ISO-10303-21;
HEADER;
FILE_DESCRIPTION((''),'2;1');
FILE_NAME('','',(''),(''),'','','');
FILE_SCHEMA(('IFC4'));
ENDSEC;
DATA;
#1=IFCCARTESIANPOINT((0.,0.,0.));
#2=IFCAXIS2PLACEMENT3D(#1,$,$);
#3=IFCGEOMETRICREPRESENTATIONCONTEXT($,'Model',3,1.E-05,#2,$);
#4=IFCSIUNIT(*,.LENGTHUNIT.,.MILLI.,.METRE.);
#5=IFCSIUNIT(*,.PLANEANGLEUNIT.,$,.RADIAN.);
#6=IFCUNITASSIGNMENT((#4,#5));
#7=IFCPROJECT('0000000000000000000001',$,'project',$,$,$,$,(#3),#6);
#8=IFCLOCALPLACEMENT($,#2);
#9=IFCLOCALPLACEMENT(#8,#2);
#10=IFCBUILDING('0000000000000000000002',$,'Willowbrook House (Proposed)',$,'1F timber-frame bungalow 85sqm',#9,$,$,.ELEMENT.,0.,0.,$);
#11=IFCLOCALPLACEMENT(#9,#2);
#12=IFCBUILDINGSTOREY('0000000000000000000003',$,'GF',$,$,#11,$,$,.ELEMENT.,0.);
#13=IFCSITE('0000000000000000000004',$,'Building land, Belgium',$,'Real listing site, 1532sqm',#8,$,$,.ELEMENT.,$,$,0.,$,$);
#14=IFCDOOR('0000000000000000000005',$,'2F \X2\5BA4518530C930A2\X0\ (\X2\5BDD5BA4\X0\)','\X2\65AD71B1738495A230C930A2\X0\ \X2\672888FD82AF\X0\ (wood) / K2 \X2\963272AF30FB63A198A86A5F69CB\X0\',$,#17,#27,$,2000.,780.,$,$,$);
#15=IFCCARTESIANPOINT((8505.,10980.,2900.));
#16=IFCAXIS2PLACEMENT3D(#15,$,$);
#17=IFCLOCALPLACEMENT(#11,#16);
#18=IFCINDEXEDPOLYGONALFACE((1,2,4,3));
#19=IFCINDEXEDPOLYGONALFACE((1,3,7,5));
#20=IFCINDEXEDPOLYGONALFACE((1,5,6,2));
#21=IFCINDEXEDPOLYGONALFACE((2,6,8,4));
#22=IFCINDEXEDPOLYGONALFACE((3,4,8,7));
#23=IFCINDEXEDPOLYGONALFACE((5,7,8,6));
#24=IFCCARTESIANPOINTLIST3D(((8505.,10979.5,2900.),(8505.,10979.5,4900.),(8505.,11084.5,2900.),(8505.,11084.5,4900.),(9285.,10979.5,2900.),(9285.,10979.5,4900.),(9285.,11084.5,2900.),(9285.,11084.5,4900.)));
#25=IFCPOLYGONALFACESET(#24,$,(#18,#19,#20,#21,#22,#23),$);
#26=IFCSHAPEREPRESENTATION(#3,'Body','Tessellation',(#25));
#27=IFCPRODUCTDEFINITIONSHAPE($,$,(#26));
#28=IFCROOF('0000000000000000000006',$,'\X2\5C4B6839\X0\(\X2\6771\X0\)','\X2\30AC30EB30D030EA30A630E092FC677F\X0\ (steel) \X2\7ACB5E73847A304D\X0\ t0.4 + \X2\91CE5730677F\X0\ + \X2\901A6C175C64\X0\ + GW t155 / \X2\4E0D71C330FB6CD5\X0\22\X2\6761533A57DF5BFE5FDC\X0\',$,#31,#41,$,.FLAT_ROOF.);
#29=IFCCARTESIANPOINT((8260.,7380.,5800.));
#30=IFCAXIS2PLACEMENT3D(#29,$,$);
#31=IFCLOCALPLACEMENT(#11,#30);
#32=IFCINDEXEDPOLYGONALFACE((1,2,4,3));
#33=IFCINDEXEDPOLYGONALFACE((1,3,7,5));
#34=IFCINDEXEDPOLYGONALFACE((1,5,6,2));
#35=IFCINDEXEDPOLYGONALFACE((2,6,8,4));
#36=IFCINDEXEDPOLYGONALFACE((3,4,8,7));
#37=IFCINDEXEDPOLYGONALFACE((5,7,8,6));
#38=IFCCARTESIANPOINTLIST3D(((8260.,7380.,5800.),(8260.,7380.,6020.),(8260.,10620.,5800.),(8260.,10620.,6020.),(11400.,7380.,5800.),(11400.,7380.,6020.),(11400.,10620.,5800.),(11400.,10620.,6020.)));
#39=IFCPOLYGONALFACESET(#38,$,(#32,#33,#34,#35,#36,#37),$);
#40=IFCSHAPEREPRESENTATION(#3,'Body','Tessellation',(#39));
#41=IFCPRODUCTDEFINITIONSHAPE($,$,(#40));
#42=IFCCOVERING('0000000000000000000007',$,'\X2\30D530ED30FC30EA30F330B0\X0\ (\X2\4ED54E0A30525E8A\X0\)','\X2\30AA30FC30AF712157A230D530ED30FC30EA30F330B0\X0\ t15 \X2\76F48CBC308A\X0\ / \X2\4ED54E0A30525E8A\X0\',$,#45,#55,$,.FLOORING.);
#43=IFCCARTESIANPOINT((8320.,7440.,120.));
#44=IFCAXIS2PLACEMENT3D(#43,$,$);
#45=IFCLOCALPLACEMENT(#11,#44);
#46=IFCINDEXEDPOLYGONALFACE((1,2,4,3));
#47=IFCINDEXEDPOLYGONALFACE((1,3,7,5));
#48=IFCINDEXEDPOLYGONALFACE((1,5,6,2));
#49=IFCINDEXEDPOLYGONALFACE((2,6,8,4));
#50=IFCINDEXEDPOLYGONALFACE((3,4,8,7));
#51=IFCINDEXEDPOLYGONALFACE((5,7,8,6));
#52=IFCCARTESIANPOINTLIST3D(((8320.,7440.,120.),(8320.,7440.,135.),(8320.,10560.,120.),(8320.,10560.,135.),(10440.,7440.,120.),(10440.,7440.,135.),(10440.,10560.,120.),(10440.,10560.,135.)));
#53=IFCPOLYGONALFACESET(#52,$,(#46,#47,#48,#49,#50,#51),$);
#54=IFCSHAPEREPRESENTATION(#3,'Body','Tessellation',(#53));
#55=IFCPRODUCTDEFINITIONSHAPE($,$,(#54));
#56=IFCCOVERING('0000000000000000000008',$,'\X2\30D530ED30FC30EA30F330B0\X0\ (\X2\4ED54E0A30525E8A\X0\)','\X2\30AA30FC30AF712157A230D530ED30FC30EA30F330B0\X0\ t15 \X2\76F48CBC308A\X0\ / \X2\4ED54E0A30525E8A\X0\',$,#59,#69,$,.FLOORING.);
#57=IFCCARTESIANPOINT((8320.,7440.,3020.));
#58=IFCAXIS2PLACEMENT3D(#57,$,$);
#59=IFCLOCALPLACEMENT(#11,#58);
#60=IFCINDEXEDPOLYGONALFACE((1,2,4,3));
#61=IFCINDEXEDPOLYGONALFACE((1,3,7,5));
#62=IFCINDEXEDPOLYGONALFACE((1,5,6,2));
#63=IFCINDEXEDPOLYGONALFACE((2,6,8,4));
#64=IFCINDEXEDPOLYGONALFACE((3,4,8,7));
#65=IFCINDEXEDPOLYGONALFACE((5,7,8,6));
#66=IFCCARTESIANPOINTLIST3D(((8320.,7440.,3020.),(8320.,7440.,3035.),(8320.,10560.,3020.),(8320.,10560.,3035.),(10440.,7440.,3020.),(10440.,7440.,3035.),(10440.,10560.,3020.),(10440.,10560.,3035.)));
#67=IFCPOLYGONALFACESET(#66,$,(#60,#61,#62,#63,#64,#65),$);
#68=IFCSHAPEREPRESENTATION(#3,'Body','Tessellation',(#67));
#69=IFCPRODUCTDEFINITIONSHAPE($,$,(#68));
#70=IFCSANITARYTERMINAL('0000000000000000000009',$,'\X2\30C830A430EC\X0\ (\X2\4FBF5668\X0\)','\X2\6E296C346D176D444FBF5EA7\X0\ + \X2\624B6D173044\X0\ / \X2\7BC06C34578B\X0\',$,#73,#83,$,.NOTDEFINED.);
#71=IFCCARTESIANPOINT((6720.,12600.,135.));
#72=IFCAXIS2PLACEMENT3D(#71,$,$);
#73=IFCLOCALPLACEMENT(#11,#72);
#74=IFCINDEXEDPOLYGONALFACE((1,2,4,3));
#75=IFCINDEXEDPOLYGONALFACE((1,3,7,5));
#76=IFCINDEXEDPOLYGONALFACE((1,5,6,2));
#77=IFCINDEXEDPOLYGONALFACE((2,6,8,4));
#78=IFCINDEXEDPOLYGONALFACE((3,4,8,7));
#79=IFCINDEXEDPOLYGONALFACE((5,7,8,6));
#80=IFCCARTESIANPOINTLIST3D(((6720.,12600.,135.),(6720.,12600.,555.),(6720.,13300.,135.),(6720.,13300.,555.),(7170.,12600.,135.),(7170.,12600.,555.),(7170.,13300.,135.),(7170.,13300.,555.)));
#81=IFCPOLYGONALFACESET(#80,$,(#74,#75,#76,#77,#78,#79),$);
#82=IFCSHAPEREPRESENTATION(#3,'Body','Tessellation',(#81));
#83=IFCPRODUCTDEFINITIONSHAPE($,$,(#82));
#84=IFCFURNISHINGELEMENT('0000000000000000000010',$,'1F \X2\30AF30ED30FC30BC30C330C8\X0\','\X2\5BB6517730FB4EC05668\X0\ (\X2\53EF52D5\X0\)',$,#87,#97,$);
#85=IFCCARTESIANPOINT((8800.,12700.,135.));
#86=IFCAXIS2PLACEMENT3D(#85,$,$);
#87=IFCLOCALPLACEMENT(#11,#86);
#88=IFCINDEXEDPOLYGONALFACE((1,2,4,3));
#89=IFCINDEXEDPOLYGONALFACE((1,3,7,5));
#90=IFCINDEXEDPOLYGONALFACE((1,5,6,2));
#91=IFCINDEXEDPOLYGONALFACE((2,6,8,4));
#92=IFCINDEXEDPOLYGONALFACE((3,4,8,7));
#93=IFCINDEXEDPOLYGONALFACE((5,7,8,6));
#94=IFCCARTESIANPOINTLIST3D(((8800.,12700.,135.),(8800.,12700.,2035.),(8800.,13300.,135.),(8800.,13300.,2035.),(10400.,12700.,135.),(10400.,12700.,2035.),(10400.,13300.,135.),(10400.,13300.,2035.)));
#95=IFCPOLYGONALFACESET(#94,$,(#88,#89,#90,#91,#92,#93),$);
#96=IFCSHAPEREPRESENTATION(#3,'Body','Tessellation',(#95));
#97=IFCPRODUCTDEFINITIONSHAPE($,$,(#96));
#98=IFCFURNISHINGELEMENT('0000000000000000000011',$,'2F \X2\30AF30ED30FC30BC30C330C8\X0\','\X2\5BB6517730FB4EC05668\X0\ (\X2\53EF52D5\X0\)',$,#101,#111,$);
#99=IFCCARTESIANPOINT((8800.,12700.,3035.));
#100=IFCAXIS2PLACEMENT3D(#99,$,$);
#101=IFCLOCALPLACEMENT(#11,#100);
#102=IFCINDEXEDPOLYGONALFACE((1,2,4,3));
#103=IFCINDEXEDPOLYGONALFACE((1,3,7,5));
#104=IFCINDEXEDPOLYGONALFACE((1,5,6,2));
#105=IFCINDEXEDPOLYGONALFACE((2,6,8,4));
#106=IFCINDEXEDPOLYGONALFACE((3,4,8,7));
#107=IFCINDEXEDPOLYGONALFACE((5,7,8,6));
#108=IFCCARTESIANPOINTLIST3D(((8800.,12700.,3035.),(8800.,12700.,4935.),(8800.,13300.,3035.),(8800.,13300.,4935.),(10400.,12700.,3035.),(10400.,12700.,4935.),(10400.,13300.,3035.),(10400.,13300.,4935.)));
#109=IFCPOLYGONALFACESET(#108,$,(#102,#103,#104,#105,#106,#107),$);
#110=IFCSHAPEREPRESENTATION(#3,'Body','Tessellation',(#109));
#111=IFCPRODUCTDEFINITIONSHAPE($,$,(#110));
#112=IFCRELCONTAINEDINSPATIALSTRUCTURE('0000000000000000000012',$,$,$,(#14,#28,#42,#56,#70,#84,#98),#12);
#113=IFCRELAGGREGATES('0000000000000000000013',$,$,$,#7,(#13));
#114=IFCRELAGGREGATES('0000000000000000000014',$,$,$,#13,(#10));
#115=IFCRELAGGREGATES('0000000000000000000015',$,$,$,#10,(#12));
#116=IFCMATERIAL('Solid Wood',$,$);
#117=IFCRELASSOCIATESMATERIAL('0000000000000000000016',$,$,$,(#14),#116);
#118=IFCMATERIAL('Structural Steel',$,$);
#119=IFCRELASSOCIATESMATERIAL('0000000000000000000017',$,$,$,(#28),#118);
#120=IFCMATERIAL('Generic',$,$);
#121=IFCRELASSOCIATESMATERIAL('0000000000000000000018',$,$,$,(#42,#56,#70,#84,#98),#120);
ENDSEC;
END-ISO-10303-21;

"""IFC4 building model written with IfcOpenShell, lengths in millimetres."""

from ifc_helpers import new_model, si_unit, frame, frame_2d, origin, place, context, project, spatial, rectangle, extrude, material, element, save


model = new_model("IFC4")

# Units and contexts
model_context = context("Model", 3, precision=1e-05, world=origin())
ifc_project = project(units=[si_unit("LENGTHUNIT", "METRE", prefix="MILLI"), si_unit("PLANEANGLEUNIT", "RADIAN")], contexts=[model_context])

# Site, building, storey
site_placement = place(None, origin())
site = spatial("IfcSite", under=ifc_project, at=site_placement, Name="Building land, Belgium", ObjectType="Real listing site, 1532sqm", CompositionType="ELEMENT", RefElevation=0.0)
building_placement = place(site_placement, origin())
building = spatial("IfcBuilding", under=site, at=building_placement, Name="Willowbrook House (Proposed)", ObjectType="1F timber-frame bungalow 85sqm", CompositionType="ELEMENT", ElevationOfRefHeight=0.0, ElevationOfTerrain=0.0)
storey_placement = place(building_placement, origin())
storey = spatial("IfcBuildingStorey", under=building, at=storey_placement, Name="GF", CompositionType="ELEMENT", Elevation=0.0)

# Shared definitions
ifc_material_1 = material(Name="Solid Wood")

# Door
door_1_placement = place(storey_placement, frame((8505.0, 10980.0, 2900.0)))
element("IfcDoor", 1, at=door_1_placement, inside=storey, material=ifc_material_1, Name="2F 室内ドア (寝室)", Description="断熱玄関ドア 木製芯 (wood) / K2 防犯・採風機構", OverallHeight=2000.0, OverallWidth=780.0, context=model_context, shape_type="SweptSolid", body=[
    extrude(rectangle(XDim=780.0, YDim=105.0, at=frame_2d((390.0, 52.0))), frame((8505.0, 10980.0, 2900.0)), (0.0, 0.0, 1.0), 2000.0),
])

# Roof
ifc_material_2 = material(Name="Structural Steel")
roof_placement = place(storey_placement, frame((8260.0, 7380.0, 5800.0)))
element("IfcRoof", 2, at=roof_placement, inside=storey, material=ifc_material_2, Name="屋根(東)", Description="ガルバリウム鋼板 (steel) 立平葺き t0.4 + 野地板 + 通気層 + GW t155 / 不燃・法22条区域対応", PredefinedType="FLAT_ROOF", context=model_context, shape_type="SweptSolid", body=[
    extrude(rectangle(XDim=3140.0, YDim=3240.0, at=frame_2d((1570.0, 1620.0))), frame((8260.0, 7380.0, 5800.0)), (0.0, 0.0, 1.0), 220.0),
])

# Coverings
ifc_material_3 = material(Name="Generic")
covering_1_placement = place(storey_placement, frame((8320.0, 7440.0, 120.0)))
element("IfcCovering", 3, at=covering_1_placement, inside=storey, material=ifc_material_3, Name="フローリング (仕上げ床)", Description="オーク無垢フローリング t15 直貼り / 仕上げ床", PredefinedType="FLOORING", context=model_context, shape_type="SweptSolid", body=[
    extrude(rectangle(XDim=2120.0, YDim=3120.0, at=frame_2d((1060.0, 1560.0))), frame((8320.0, 7440.0, 120.0)), (0.0, 0.0, 1.0), 15.0),
])
covering_2_placement = place(storey_placement, frame((8320.0, 7440.0, 3020.0)))
element("IfcCovering", 4, at=covering_2_placement, inside=storey, material=ifc_material_3, Name="フローリング (仕上げ床)", Description="オーク無垢フローリング t15 直貼り / 仕上げ床", PredefinedType="FLOORING", context=model_context, shape_type="SweptSolid", body=[
    extrude(rectangle(XDim=2120.0, YDim=3120.0, at=frame_2d((1060.0, 1560.0))), frame((8320.0, 7440.0, 3020.0)), (0.0, 0.0, 1.0), 15.0),
])

# Sanitary terminal
sanitary_terminal_placement = place(storey_placement, frame((6720.0, 12600.0, 135.0)))
element("IfcSanitaryTerminal", 5, at=sanitary_terminal_placement, inside=storey, material=ifc_material_3, Name="トイレ (便器)", Description="温水洗浄便座 + 手洗い / 節水型", PredefinedType="NOTDEFINED", context=model_context, shape_type="SweptSolid", body=[
    extrude(rectangle(XDim=450.0, YDim=700.0, at=frame_2d((225.0, 350.0))), frame((6720.0, 12600.0, 135.0)), (0.0, 0.0, 1.0), 420.0),
])

# Furnishing elements
furnishing_1_placement = place(storey_placement, frame((8800.0, 12700.0, 135.0)))
element("IfcFurnishingElement", 6, at=furnishing_1_placement, inside=storey, material=ifc_material_3, Name="1F クローゼット", Description="家具・什器 (可動)", context=model_context, shape_type="SweptSolid", body=[
    extrude(rectangle(XDim=1600.0, YDim=600.0, at=frame_2d((800.0, 300.0))), frame((8800.0, 12700.0, 135.0)), (0.0, 0.0, 1.0), 1900.0),
])
furnishing_2_placement = place(storey_placement, frame((8800.0, 12700.0, 3035.0)))
element("IfcFurnishingElement", 7, at=furnishing_2_placement, inside=storey, material=ifc_material_3, Name="2F クローゼット", Description="家具・什器 (可動)", context=model_context, shape_type="SweptSolid", body=[
    extrude(rectangle(XDim=1600.0, YDim=600.0, at=frame_2d((800.0, 300.0))), frame((8800.0, 12700.0, 3035.0)), (0.0, 0.0, 1.0), 1900.0),
])

save(model, "model.ifc")
